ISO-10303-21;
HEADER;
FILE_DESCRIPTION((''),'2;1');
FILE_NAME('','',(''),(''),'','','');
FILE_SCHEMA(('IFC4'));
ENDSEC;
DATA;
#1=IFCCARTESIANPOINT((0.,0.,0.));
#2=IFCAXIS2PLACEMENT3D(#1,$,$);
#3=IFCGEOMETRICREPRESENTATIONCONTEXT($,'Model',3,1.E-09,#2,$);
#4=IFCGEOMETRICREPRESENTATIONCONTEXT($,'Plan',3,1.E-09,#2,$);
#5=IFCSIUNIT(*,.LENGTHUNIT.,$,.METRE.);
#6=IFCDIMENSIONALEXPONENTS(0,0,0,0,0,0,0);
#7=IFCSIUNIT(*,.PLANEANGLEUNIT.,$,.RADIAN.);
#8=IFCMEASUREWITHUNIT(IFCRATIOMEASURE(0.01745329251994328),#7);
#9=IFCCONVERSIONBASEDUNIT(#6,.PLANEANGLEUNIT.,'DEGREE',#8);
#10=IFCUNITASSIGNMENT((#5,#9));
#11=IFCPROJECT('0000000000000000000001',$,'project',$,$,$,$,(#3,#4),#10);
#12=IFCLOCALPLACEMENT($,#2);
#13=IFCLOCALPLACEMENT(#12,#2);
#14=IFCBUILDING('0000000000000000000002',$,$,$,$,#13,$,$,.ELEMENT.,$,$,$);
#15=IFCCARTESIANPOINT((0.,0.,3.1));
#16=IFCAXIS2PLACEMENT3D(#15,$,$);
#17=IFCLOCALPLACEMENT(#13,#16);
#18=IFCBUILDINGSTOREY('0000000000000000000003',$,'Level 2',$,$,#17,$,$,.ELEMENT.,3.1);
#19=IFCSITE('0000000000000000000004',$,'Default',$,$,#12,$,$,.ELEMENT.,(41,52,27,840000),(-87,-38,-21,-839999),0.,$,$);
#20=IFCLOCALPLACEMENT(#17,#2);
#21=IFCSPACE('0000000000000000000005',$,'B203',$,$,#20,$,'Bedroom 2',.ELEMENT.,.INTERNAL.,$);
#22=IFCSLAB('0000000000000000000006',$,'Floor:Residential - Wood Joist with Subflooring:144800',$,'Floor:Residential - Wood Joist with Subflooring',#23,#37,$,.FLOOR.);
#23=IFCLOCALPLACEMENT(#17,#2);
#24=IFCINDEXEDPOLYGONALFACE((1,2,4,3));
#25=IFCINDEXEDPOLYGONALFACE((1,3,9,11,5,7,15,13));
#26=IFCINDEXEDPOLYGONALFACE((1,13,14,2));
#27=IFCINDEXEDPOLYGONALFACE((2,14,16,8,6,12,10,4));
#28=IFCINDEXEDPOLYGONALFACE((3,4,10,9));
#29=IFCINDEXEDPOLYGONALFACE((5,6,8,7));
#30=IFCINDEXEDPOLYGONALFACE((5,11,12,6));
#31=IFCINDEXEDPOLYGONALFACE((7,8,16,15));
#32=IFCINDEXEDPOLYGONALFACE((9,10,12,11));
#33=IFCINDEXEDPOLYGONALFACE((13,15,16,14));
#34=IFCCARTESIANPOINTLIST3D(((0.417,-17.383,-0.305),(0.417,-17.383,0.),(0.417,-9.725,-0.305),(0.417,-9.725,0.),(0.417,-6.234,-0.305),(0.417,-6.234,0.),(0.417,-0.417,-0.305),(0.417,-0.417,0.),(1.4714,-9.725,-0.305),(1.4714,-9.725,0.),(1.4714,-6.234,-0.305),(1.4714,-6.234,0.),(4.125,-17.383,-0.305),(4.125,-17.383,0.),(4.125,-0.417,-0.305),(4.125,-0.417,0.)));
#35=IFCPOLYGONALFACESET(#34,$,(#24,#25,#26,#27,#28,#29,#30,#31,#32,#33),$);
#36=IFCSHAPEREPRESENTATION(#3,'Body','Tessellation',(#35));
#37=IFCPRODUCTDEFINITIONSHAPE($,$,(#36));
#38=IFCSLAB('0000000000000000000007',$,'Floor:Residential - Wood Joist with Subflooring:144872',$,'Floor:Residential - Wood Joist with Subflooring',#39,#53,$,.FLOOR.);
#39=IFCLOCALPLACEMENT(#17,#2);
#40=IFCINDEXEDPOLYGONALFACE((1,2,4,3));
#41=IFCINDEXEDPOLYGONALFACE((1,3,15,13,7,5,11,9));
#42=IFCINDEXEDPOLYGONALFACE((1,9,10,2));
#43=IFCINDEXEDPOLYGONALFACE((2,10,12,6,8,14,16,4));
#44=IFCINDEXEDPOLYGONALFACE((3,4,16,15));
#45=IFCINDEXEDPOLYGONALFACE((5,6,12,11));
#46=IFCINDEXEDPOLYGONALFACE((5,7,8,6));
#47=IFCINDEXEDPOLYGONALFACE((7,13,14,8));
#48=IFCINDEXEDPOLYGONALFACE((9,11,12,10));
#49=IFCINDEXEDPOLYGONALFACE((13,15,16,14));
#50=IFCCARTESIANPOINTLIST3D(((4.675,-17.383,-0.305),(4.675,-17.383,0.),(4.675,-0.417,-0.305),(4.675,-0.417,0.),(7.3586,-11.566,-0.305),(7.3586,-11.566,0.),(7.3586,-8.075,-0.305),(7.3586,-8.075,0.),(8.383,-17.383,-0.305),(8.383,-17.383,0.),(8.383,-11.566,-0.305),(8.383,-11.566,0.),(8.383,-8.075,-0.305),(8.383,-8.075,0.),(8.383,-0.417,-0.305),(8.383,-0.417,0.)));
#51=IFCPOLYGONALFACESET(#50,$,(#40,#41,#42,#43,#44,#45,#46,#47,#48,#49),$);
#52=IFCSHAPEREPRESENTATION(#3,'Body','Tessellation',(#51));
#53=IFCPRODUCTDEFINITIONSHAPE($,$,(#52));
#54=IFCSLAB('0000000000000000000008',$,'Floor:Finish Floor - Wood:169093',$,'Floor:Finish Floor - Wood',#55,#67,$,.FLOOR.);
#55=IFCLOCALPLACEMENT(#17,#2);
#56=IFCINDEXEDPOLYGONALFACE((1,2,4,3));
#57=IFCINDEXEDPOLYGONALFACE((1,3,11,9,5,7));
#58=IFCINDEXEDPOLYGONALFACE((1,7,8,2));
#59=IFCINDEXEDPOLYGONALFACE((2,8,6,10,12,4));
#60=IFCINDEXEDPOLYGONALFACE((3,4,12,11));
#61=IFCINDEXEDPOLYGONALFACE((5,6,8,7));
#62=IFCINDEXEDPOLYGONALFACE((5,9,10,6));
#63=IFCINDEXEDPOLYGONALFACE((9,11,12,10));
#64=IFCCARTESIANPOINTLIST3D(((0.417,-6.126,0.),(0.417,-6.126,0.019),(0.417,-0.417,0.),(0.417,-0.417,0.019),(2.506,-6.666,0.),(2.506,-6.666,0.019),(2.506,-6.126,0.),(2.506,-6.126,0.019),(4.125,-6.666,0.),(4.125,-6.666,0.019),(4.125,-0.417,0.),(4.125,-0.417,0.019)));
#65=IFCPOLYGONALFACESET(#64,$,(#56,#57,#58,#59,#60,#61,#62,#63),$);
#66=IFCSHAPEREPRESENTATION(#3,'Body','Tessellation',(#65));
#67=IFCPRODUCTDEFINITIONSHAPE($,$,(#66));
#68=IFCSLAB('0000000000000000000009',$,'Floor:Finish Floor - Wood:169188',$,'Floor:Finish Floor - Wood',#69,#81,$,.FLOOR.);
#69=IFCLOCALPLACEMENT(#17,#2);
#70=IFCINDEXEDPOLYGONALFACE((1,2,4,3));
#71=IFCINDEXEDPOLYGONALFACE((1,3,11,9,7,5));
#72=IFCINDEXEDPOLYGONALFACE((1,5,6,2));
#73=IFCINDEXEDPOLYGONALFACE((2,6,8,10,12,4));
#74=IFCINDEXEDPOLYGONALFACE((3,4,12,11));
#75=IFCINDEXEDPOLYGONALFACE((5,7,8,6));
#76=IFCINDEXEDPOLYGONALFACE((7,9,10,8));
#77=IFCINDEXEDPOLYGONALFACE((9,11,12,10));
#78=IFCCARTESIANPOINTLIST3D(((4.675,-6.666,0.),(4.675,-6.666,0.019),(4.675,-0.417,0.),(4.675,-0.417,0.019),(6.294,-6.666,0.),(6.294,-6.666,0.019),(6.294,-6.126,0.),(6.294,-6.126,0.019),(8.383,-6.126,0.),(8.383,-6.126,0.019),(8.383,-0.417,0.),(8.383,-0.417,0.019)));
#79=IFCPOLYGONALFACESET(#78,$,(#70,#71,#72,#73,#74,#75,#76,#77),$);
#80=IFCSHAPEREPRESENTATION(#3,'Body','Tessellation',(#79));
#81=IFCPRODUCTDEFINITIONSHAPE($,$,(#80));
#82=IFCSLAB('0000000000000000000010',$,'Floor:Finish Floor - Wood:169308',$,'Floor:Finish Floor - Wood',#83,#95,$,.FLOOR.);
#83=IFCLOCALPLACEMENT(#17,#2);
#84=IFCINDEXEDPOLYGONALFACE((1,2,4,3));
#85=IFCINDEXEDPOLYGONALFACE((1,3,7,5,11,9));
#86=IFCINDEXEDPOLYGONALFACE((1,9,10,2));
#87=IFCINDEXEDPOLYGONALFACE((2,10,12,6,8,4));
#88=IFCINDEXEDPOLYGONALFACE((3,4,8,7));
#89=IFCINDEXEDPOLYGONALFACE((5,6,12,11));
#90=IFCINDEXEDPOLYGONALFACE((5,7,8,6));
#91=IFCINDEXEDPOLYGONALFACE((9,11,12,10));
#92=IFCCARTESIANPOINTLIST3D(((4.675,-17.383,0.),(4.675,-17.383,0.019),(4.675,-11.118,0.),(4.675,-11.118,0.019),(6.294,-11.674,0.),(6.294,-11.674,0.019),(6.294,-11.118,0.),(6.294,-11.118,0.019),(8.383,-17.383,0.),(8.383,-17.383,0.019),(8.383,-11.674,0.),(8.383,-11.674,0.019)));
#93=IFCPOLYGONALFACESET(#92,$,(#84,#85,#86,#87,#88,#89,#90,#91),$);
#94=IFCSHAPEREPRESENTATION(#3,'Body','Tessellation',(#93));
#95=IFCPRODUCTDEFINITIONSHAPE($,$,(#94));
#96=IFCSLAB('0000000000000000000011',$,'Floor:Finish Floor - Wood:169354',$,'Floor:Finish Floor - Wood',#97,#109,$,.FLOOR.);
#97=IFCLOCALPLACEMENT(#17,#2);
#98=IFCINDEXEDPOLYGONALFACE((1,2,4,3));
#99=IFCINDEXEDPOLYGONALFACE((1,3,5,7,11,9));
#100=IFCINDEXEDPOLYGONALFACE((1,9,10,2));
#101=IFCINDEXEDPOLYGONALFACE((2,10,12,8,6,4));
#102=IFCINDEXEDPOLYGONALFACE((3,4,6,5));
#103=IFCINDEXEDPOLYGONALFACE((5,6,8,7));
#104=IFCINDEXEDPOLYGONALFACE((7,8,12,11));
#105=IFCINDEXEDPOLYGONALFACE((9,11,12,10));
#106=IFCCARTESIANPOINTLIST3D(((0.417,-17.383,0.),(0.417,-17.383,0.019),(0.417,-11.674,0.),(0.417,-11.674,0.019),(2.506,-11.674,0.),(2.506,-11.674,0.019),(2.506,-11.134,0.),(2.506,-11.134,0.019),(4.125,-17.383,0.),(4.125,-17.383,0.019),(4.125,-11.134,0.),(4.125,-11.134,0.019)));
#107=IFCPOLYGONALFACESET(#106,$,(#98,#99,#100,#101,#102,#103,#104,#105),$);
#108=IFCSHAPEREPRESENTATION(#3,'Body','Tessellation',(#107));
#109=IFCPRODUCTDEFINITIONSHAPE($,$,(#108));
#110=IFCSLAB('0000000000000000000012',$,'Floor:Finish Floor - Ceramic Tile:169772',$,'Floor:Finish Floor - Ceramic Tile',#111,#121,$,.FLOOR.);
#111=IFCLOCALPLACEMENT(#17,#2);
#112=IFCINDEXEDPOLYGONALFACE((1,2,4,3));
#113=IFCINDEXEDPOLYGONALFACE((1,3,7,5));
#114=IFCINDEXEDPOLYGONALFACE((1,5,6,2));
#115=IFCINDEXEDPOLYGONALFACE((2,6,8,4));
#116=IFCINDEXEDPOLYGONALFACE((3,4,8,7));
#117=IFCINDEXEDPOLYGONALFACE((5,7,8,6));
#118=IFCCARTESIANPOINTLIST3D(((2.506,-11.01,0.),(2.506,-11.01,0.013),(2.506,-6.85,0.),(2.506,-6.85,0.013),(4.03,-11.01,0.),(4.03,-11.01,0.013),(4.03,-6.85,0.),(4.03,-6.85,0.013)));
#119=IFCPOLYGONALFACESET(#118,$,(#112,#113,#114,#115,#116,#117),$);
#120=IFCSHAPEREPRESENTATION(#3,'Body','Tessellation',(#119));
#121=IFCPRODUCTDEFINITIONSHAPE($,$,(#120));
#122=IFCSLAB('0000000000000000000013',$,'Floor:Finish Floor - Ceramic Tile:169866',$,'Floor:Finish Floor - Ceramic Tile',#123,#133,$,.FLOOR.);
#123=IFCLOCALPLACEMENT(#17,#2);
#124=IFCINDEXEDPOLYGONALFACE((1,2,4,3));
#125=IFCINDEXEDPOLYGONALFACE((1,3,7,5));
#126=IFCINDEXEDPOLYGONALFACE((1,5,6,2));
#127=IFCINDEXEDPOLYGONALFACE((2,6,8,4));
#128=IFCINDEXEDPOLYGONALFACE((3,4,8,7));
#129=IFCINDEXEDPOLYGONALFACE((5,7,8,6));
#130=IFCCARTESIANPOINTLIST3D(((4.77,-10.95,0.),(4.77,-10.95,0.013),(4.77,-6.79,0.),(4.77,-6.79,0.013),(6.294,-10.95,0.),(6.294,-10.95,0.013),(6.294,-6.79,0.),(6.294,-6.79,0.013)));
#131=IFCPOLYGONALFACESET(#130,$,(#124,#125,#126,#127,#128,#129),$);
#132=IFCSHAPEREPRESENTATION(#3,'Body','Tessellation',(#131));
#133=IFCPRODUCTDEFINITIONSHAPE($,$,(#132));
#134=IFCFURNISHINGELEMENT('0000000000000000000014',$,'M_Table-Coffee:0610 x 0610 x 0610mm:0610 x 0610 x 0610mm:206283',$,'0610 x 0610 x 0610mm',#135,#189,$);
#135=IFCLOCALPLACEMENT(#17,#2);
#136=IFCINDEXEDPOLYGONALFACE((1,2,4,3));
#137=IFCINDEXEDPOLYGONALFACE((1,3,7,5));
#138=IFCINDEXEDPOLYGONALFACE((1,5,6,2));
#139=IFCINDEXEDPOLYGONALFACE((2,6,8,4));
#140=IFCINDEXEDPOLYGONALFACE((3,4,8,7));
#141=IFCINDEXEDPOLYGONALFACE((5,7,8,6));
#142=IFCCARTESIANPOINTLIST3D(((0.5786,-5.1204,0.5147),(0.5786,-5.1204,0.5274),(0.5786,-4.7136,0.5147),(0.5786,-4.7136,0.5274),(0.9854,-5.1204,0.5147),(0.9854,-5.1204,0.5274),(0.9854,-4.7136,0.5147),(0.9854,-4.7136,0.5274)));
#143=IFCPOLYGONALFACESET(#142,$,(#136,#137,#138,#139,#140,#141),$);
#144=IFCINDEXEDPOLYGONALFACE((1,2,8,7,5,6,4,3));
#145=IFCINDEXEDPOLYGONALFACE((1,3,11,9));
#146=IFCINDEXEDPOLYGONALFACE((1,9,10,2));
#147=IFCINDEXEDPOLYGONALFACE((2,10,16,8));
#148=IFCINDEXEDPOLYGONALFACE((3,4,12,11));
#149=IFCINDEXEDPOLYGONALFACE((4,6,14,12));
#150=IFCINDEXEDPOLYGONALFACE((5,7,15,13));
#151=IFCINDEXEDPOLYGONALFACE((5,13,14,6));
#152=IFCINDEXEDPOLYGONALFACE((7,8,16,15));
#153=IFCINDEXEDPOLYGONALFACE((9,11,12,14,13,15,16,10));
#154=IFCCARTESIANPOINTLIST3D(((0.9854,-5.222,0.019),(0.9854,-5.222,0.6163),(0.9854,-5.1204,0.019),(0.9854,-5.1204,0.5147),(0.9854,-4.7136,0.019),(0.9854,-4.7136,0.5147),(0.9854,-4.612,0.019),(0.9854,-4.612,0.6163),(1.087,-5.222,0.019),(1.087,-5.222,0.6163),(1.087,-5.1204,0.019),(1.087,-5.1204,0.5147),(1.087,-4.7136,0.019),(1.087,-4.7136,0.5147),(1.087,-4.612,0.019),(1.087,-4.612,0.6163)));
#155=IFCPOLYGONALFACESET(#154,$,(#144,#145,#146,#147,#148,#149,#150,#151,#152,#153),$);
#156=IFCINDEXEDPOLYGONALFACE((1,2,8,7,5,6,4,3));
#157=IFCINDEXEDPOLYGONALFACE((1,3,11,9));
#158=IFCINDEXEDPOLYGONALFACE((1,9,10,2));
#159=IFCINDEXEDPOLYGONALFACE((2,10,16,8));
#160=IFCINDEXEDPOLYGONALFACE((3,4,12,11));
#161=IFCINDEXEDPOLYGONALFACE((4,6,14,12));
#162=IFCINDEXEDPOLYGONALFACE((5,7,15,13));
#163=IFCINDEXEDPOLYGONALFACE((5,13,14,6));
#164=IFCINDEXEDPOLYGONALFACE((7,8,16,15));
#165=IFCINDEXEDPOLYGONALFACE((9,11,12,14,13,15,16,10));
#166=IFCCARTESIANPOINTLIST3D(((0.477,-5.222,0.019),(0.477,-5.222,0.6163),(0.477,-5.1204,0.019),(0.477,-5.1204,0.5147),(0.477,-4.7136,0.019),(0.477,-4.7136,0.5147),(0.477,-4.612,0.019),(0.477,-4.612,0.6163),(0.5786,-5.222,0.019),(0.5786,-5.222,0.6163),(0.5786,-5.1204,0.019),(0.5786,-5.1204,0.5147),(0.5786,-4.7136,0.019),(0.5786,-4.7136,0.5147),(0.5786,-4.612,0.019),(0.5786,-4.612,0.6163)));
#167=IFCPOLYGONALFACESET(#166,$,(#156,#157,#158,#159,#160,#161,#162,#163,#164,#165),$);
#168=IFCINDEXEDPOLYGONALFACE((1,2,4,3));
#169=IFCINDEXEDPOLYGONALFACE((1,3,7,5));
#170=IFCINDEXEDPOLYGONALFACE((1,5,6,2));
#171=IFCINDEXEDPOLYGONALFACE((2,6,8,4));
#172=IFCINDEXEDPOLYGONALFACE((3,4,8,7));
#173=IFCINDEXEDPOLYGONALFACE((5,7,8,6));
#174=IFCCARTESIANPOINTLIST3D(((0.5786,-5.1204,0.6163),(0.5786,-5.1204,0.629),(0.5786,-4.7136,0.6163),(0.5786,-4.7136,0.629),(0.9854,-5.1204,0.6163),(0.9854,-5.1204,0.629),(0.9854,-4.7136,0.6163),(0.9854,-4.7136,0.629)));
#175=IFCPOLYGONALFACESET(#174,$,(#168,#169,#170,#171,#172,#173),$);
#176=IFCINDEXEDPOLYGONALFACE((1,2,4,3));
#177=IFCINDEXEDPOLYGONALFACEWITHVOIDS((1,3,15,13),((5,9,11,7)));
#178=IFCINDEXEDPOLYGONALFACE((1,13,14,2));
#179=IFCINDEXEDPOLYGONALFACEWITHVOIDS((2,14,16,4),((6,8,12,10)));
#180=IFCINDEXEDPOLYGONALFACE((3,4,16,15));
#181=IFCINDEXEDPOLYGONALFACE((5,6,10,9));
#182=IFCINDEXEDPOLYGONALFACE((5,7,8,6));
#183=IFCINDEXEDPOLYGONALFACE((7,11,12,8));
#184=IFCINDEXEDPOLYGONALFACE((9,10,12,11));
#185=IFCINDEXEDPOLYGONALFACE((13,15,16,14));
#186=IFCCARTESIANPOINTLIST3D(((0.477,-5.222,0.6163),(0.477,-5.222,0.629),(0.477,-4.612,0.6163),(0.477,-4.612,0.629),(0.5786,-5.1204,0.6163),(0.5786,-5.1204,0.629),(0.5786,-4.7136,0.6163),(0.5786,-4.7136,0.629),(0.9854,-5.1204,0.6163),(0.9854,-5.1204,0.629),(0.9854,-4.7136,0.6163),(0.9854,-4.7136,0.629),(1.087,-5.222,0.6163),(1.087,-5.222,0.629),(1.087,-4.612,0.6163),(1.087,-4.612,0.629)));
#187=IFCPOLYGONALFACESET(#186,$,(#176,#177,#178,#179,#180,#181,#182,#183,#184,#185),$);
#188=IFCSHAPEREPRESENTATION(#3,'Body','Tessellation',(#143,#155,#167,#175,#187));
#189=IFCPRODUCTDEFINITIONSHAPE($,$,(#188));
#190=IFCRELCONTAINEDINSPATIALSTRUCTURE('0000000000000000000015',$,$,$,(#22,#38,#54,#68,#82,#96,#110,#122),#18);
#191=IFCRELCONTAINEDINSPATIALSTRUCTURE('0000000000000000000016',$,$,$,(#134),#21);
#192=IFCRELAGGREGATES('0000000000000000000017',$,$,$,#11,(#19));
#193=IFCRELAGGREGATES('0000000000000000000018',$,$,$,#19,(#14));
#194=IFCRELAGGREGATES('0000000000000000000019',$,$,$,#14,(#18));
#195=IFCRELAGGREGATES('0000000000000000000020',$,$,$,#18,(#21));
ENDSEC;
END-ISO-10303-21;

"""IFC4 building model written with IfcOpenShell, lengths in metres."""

from ifc_helpers import new_model, entity, si_unit, converted_unit, frame, frame_2d, origin, origin_2d_with_axis, place, context, project, spatial, polyline, rectangle, outline, extrude, source, transform, mapped, element, save


model = new_model("IFC4")

# Units and contexts
model_context = context("Model", 3, precision=1e-09, world=origin())
plan_context = context("Plan", 3, precision=1e-09, world=origin())
ifc_project = project(units=[si_unit("LENGTHUNIT", "METRE"), converted_unit("PLANEANGLEUNIT", "DEGREE", entity("IfcRatioMeasure", 0.01745329251994328), si_unit("PLANEANGLEUNIT", "RADIAN"), dimensions=[0, 0, 0, 0, 0, 0, 0])], contexts=[model_context, plan_context])

# Site, building, storey
site_placement = place(None, origin())
site = spatial("IfcSite", under=ifc_project, at=site_placement, Name="Default", CompositionType="ELEMENT", RefLatitude=(41, 52, 27, 840000), RefLongitude=(-87, -38, -21, -839999), RefElevation=0.0)
building_placement = place(site_placement, origin())
building = spatial("IfcBuilding", under=site, at=building_placement, CompositionType="ELEMENT")
storey_placement = place(building_placement, frame((0.0, 0.0, 3.1)))
storey = spatial("IfcBuildingStorey", under=building, at=storey_placement, Name="Level 2", CompositionType="ELEMENT", Elevation=3.1)

# Slabs
slab_1_placement = place(storey_placement, frame((0.417, -17.383, -0.305)))
element("IfcSlab", 1, at=slab_1_placement, inside=storey, Name="Floor:Residential - Wood Joist with Subflooring:144800", ObjectType="Floor:Residential - Wood Joist with Subflooring", PredefinedType="FLOOR", context=model_context, shape_type="SweptSolid", body=[
    extrude(outline(polyline([(-1.854, 8.483), (-1.854, -8.483), (1.854, -8.483), (1.854, -0.825), (0.7996, -0.825), (0.7996, 2.666), (1.854, 2.666), (1.854, 8.483), (-1.854, 8.483)])), frame((1.854, 8.483, 0.305), z_axis=(0.0, 0.0, -1.0), x_axis=(-1.0, 0.0, 0.0)), (0.0, 0.0, 1.0), 0.305),
])
slab_2_placement = place(storey_placement, frame((4.675, -17.383, -0.305)))
element("IfcSlab", 2, at=slab_2_placement, inside=storey, Name="Floor:Residential - Wood Joist with Subflooring:144872", ObjectType="Floor:Residential - Wood Joist with Subflooring", PredefinedType="FLOOR", context=model_context, shape_type="SweptSolid", body=[
    extrude(outline(polyline([(-1.854, 8.483), (-1.854, 0.825), (-0.8296, 0.825), (-0.8296, -2.666), (-1.854, -2.666), (-1.854, -8.483), (1.854, -8.483), (1.854, 8.483), (-1.854, 8.483)])), frame((1.854, 8.483, 0.305), z_axis=(0.0, 0.0, -1.0), x_axis=(-1.0, 0.0, 0.0)), (0.0, 0.0, 1.0), 0.305),
])
slab_3_placement = place(storey_placement, frame((0.417, -6.666, 0.0)))
element("IfcSlab", 3, at=slab_3_placement, inside=storey, Name="Floor:Finish Floor - Wood:169093", ObjectType="Floor:Finish Floor - Wood", PredefinedType="FLOOR", context=model_context, shape_type="SweptSolid", body=[
    extrude(outline(polyline([(1.854, 3.1245), (-1.854, 3.1245), (-1.854, -3.1245), (-0.235, -3.1245), (-0.235, -2.5845), (1.854, -2.5845), (1.854, 3.1245)])), frame((1.854, 3.1245, 0.019), z_axis=(0.0, 0.0, -1.0), x_axis=(-1.0, 0.0, 0.0)), (0.0, 0.0, 1.0), 0.019),
])
slab_4_placement = place(storey_placement, frame((4.675, -6.666, 0.0)))
element("IfcSlab", 4, at=slab_4_placement, inside=storey, Name="Floor:Finish Floor - Wood:169188", ObjectType="Floor:Finish Floor - Wood", PredefinedType="FLOOR", context=model_context, shape_type="SweptSolid", body=[
    extrude(outline(polyline([(-1.854, 3.1245), (-1.854, -2.5845), (0.235, -2.5845), (0.235, -3.1245), (1.854, -3.1245), (1.854, 3.1245), (-1.854, 3.1245)])), frame((1.854, 3.1245, 0.019), z_axis=(0.0, 0.0, -1.0), x_axis=(-1.0, 0.0, 0.0)), (0.0, 0.0, 1.0), 0.019),
])
slab_5_placement = place(storey_placement, frame((4.675, -17.383, 0.0)))
element("IfcSlab", 5, at=slab_5_placement, inside=storey, Name="Floor:Finish Floor - Wood:169308", ObjectType="Floor:Finish Floor - Wood", PredefinedType="FLOOR", context=model_context, shape_type="SweptSolid", body=[
    extrude(outline(polyline([(-1.854, 2.5765), (-1.854, -3.1325), (1.854, -3.1325), (1.854, 3.1325), (0.235, 3.1325), (0.235, 2.5765), (-1.854, 2.5765)])), frame((1.854, 3.1325, 0.019), z_axis=(0.0, 0.0, -1.0), x_axis=(-1.0, 0.0, 0.0)), (0.0, 0.0, 1.0), 0.019),
])
slab_6_placement = place(storey_placement, frame((0.417, -17.383, 0.0)))
element("IfcSlab", 6, at=slab_6_placement, inside=storey, Name="Floor:Finish Floor - Wood:169354", ObjectType="Floor:Finish Floor - Wood", PredefinedType="FLOOR", context=model_context, shape_type="SweptSolid", body=[
    extrude(outline(polyline([(-1.854, -3.1245), (1.854, -3.1245), (1.854, 2.5845), (-0.235, 2.5845), (-0.235, 3.1245), (-1.854, 3.1245), (-1.854, -3.1245)])), frame((1.854, 3.1245, 0.019), z_axis=(0.0, 0.0, -1.0), x_axis=(-1.0, 0.0, 0.0)), (0.0, 0.0, 1.0), 0.019),
])
slab_7_placement = place(storey_placement, frame((2.506, -11.01, 0.0)))
element("IfcSlab", 7, at=slab_7_placement, inside=storey, Name="Floor:Finish Floor - Ceramic Tile:169772", ObjectType="Floor:Finish Floor - Ceramic Tile", PredefinedType="FLOOR", context=model_context, shape_type="SweptSolid", body=[
    extrude(rectangle(XDim=4.16, YDim=1.524, at=frame_2d((0.0, 0.0), x_axis=(0.0, -1.0))), frame((0.762, 2.08, 0.013), z_axis=(0.0, 0.0, -1.0), x_axis=(-1.0, 0.0, 0.0)), (0.0, 0.0, 1.0), 0.013),
])
slab_8_placement = place(storey_placement, frame((4.77, -10.95, 0.0)))
element("IfcSlab", 8, at=slab_8_placement, inside=storey, Name="Floor:Finish Floor - Ceramic Tile:169866", ObjectType="Floor:Finish Floor - Ceramic Tile", PredefinedType="FLOOR", context=model_context, shape_type="SweptSolid", body=[
    extrude(rectangle(XDim=4.16, YDim=1.524, at=frame_2d((0.0, 0.0), x_axis=(0.0, -1.0))), frame((0.762, 2.08, 0.013), z_axis=(0.0, 0.0, -1.0), x_axis=(-1.0, 0.0, 0.0)), (0.0, 0.0, 1.0), 0.013),
])

# Shared definitions
space_1_placement = place(storey_placement, origin())
space_1 = spatial("IfcSpace", under=storey, at=space_1_placement, Name="B203", LongName="Bedroom 2", CompositionType="ELEMENT", PredefinedType="INTERNAL")

# Furnishing element
shared_shape = source(origin(), model_context, "Body", "SweptSolid", [
    extrude(rectangle(XDim=0.4068, YDim=0.4068, at=origin_2d_with_axis()), frame((0.0183, 0.0952, 0.4957), z_axis=(0.0, 0.0, 1.0), x_axis=(-1.0, 0.0, 0.0)), (0.0, 0.0, 1.0), 0.0127),
    extrude(outline(polyline([(-0.2732, -0.305), (0.324, -0.305), (0.324, 0.305), (-0.2732, 0.305), (-0.2732, 0.2034), (0.2225, 0.2034), (0.2225, -0.2034), (-0.2732, -0.2034), (-0.2732, -0.305)])), frame((0.2217, 0.0952, 0.2732), z_axis=(1.0, 0.0, 0.0), x_axis=(0.0, 0.0, 1.0)), (0.0, 0.0, 1.0), 0.1016),
    extrude(outline(polyline([(-0.305, -0.3241), (0.305, -0.3241), (0.305, 0.2733), (0.2034, 0.2733), (0.2034, -0.2224), (-0.2034, -0.2224), (-0.2034, 0.2733), (-0.305, 0.2733), (-0.305, -0.3241)])), frame((-0.2867, 0.0952, 0.2733), z_axis=(1.0, 0.0, 0.0), x_axis=(0.0, -1.0, 0.0)), (0.0, 0.0, 1.0), 0.1016),
    extrude(rectangle(XDim=0.4068, YDim=0.4068, at=origin_2d_with_axis()), frame((0.0183, 0.0952, 0.5973), z_axis=(0.0, 0.0, 1.0), x_axis=(-1.0, 0.0, 0.0)), (0.0, 0.0, 1.0), 0.0127),
    extrude(outline(polyline([(-0.305, -0.305), (0.305, -0.305), (0.305, 0.305), (-0.305, 0.305), (-0.305, -0.305)]), holes=[polyline([(-0.2034, -0.2034), (-0.2034, 0.2034), (0.2034, 0.2034), (0.2034, -0.2034), (-0.2034, -0.2034)])]), frame((0.0183, 0.0952, 0.5973), z_axis=(0.0, 0.0, 1.0), x_axis=(-1.0, 0.0, 0.0)), (0.0, 0.0, 1.0), 0.0127),
])
furnishing_1_placement = place(space_1_placement, frame((0.7637, -5.0122, 0.019)))
element("IfcFurnishingElement", 9, at=furnishing_1_placement, inside=space_1, Name="M_Table-Coffee:0610 x 0610 x 0610mm:0610 x 0610 x 0610mm:206283", ObjectType="0610 x 0610 x 0610mm", context=model_context, shape_type="MappedRepresentation", body=[
    mapped(shared_shape, transform((0.0, 0.0, 0.0), scale=1.0)),
])

save(model, "model.ifc")
